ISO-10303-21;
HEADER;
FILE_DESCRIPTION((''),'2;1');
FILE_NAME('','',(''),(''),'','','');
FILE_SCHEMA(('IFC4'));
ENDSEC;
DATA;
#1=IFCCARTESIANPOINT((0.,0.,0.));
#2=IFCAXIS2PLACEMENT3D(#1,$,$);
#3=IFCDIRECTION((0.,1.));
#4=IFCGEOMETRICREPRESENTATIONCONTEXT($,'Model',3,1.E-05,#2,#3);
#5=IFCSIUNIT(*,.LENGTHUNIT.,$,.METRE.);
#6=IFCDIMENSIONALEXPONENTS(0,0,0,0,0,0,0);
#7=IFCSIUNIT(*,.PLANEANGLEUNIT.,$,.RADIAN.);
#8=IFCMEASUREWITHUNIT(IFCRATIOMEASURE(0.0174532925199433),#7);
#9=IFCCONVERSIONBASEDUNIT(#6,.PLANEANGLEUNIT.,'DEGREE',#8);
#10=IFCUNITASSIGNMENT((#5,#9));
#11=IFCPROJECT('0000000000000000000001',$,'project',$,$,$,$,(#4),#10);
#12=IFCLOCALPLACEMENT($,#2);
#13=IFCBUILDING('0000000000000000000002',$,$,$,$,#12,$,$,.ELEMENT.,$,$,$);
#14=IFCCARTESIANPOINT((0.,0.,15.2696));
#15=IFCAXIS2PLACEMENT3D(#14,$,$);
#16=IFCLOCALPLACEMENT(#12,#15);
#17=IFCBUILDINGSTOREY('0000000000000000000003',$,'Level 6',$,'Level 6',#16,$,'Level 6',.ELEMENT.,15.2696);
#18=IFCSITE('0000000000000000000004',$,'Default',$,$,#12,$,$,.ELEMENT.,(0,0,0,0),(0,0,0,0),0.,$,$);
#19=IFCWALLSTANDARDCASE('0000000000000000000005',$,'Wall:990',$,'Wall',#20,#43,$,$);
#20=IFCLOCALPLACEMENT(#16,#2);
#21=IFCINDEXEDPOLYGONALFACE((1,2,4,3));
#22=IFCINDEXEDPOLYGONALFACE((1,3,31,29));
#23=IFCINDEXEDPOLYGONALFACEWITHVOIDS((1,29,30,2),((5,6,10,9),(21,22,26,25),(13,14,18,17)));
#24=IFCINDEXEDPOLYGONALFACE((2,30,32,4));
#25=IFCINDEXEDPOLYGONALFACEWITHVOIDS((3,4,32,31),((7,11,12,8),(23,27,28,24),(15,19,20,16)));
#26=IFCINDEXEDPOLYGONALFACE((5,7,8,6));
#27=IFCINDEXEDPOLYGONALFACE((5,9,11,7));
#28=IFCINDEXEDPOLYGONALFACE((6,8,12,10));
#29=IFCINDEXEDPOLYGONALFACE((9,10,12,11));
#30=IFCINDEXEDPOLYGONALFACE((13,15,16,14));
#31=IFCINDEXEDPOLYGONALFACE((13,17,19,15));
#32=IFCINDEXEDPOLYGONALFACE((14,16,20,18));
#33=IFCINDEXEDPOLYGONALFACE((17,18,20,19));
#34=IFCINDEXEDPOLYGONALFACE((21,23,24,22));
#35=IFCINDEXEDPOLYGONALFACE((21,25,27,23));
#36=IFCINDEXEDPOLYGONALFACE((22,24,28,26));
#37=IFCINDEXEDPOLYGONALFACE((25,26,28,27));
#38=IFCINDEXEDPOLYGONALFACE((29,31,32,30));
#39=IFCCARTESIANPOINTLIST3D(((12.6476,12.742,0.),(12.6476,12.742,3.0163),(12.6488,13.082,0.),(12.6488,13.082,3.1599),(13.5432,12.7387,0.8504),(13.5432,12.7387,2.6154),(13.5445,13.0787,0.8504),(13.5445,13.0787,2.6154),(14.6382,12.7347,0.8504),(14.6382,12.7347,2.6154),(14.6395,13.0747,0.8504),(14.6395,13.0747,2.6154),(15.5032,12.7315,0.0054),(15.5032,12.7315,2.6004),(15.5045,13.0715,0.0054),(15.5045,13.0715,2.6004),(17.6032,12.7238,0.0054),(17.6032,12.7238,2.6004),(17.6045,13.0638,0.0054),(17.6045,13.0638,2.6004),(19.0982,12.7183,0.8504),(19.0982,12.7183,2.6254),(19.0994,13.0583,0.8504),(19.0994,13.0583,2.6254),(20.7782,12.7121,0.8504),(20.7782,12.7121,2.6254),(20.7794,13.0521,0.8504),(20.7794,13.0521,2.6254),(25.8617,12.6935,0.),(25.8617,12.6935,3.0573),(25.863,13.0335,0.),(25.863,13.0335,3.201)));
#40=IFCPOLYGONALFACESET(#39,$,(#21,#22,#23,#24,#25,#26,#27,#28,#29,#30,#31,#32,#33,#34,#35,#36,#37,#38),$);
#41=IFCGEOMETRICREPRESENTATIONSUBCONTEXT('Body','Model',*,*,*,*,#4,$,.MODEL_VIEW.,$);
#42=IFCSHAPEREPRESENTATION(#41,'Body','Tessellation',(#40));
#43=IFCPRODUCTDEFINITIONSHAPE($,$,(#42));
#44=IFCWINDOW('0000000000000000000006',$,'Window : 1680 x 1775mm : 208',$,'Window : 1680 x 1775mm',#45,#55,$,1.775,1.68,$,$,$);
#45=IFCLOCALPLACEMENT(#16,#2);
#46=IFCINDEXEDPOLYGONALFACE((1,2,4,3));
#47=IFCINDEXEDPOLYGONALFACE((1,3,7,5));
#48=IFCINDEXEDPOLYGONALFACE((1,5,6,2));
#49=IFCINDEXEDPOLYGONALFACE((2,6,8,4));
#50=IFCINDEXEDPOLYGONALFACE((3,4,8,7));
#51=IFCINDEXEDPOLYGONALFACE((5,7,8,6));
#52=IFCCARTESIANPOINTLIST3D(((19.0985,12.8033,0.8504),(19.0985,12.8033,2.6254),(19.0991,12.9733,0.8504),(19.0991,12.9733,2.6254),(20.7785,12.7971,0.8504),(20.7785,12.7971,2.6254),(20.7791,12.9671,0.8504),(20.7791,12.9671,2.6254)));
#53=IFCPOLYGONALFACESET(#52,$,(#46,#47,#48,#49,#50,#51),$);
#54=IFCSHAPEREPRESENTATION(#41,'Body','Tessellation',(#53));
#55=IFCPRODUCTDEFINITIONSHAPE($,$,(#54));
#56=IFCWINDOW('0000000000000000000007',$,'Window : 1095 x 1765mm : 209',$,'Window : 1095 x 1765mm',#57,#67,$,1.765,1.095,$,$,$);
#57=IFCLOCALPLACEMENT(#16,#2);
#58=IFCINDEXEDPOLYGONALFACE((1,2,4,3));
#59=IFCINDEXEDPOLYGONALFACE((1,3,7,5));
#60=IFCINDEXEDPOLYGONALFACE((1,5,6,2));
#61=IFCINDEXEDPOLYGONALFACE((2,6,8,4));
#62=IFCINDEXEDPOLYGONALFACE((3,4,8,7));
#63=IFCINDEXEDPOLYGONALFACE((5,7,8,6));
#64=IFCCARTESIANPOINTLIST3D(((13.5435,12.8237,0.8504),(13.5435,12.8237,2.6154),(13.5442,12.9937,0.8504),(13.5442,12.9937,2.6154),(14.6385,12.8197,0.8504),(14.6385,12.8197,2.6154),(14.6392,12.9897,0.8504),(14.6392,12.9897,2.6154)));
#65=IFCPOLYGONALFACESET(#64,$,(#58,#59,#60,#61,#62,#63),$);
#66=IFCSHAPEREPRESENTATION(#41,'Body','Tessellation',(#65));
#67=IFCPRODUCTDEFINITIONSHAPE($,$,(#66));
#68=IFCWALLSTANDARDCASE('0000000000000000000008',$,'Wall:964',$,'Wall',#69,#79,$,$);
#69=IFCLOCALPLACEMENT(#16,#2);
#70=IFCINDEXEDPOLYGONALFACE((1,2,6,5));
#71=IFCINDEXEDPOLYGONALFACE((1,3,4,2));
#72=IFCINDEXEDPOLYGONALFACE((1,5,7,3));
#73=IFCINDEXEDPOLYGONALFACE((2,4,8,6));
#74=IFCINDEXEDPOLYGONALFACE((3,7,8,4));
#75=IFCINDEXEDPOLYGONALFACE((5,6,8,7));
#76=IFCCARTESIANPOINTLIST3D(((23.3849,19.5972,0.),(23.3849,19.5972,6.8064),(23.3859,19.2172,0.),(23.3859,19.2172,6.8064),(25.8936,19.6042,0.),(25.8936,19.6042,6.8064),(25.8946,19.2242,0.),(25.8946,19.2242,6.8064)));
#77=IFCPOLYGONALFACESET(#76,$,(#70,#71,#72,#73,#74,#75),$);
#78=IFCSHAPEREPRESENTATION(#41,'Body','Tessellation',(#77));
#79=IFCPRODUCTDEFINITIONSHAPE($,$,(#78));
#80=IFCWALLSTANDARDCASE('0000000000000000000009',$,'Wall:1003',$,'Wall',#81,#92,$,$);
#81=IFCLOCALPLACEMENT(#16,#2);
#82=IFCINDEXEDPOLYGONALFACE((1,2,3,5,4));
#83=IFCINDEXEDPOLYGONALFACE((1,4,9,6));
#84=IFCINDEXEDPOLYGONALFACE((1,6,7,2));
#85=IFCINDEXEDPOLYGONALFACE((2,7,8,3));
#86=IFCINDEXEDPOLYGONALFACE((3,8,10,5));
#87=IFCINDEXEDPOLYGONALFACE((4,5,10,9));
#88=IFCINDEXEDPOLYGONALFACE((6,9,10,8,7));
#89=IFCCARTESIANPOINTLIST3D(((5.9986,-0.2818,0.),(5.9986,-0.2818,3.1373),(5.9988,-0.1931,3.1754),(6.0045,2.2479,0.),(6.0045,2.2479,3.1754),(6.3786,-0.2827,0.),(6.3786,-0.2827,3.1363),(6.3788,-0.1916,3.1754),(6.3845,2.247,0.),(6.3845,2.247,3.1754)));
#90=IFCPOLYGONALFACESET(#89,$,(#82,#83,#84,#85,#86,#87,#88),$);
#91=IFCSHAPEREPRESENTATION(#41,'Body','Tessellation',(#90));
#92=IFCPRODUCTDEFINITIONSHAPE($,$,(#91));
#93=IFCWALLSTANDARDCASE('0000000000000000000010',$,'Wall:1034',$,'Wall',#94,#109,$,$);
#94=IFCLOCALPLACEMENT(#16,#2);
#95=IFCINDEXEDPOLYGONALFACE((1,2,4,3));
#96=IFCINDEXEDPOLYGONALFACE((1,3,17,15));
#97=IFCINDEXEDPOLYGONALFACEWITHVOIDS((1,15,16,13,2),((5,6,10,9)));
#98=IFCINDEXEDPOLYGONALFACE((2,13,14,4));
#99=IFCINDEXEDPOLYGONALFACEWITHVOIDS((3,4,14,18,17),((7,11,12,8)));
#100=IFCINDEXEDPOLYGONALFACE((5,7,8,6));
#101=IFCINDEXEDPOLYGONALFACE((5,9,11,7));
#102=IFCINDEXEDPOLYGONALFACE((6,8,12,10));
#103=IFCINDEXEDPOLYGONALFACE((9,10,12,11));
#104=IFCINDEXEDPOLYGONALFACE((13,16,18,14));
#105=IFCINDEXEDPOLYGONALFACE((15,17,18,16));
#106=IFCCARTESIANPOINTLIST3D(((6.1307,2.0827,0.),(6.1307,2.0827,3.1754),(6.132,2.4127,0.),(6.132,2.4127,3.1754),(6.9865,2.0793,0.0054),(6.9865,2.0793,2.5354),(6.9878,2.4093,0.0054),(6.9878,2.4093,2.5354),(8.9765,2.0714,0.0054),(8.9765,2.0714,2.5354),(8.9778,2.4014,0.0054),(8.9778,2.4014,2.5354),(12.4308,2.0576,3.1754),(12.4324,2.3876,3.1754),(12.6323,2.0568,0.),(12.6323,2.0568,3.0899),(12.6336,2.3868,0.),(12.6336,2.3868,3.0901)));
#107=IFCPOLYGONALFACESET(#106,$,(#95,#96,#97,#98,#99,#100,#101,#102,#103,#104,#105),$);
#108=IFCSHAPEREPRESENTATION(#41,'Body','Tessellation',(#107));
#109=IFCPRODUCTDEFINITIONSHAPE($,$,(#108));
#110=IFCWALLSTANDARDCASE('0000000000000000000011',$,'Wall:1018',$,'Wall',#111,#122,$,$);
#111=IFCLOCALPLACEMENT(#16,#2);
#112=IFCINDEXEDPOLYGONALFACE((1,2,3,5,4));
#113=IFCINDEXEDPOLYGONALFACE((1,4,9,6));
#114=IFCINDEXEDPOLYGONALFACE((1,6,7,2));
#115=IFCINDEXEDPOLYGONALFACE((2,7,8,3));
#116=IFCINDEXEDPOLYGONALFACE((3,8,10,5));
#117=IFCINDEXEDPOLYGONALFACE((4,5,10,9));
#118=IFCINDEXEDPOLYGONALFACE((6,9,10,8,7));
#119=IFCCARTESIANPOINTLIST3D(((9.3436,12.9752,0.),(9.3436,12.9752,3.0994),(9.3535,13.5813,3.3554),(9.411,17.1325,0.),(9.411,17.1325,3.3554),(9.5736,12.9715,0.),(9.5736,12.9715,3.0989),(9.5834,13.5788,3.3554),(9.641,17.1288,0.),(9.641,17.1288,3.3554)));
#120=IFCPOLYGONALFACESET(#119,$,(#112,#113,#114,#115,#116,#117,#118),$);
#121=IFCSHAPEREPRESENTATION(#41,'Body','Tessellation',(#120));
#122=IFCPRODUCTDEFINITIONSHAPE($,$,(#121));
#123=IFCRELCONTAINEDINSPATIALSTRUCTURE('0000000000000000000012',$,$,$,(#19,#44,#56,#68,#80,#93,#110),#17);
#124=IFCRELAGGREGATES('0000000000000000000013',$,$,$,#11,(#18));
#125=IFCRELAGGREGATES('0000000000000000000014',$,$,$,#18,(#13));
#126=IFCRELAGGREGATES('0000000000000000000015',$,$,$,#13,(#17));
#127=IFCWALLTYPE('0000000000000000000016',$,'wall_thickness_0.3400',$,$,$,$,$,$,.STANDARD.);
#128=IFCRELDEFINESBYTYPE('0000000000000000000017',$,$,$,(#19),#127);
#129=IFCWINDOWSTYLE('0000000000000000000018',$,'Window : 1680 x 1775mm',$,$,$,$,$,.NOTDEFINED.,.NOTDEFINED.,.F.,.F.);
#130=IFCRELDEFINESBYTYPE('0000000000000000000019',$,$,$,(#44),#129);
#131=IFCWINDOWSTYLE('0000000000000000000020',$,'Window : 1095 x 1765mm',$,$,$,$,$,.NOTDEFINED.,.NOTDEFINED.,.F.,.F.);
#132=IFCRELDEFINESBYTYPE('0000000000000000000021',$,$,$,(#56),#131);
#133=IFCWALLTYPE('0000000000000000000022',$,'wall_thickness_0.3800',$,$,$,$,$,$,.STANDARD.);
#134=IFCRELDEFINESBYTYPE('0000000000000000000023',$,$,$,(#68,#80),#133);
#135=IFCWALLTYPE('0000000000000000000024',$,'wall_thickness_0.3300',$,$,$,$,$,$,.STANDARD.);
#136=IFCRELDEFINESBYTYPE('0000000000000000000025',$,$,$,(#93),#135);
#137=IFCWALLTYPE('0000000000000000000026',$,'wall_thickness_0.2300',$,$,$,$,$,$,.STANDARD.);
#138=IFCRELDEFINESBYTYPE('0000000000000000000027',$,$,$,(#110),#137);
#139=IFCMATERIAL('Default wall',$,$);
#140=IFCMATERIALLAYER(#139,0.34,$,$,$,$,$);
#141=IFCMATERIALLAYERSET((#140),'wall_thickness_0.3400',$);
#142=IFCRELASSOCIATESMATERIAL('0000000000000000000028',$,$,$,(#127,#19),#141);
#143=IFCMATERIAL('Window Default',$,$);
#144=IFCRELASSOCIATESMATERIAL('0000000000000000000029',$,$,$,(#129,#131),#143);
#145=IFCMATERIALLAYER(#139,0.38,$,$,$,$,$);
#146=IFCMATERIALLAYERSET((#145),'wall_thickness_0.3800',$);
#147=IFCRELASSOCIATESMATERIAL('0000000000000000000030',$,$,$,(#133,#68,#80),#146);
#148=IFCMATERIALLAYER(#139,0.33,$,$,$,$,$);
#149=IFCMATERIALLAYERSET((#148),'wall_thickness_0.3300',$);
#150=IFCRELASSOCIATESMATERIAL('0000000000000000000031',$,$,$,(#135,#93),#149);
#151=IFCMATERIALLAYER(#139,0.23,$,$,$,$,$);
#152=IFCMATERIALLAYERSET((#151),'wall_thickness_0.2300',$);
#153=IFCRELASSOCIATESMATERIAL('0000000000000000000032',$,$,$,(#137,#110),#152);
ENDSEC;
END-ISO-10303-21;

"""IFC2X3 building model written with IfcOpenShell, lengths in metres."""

from ifc_helpers import new_model, entity, si_unit, converted_unit, direction, frame, frame_2d, origin, origin_2d_with_axis, place, context, subcontext, project, spatial, polyline, rectangle, outline, extrude, clip, halfspace, source, transform, mapped, material, layer, layer_set, layer_usage, type_object, type_shapes, element, fill, save


model = new_model("IFC2X3")

# Units and contexts
model_context = context("Model", 3, precision=1e-05, world=origin(), true_north=direction((0.0, 1.0)))
body_context = subcontext(model_context, "Body", "Model", "MODEL_VIEW")
ifc_project = project(units=[si_unit("LENGTHUNIT", "METRE"), converted_unit("PLANEANGLEUNIT", "DEGREE", entity("IfcRatioMeasure", 0.0174532925199433), si_unit("PLANEANGLEUNIT", "RADIAN"), dimensions=[0, 0, 0, 0, 0, 0, 0])], contexts=[model_context])

# Site, building, storey
placement = place(None, origin())
site = spatial("IfcSite", under=ifc_project, at=placement, Name="Default", CompositionType="ELEMENT", RefLatitude=(0, 0, 0, 0), RefLongitude=(0, 0, 0, 0), RefElevation=0.0)
building = spatial("IfcBuilding", under=site, at=placement, CompositionType="ELEMENT")
storey_placement = place(placement, frame((0.0, 0.0, 15.2696)))
storey = spatial("IfcBuildingStorey", under=building, at=storey_placement, Name="Level 6", ObjectType="Level 6", LongName="Level 6", CompositionType="ELEMENT", Elevation=15.2696)

# Shared definitions
ifc_material_1 = material(Name="Default wall")

# Shared definitions
ifc_material_2 = material(Name="Window Default")

# Wall, openings, windows
ifc_layer_1 = layer(ifc_material_1, 0.34)
ifc_layer_set_1 = layer_set([ifc_layer_1], Name="wall_thickness_0.3400")
ifc_layer_usage_1 = layer_usage(ifc_layer_set_1, "AXIS2", "POSITIVE", -0.17)
wall_type_1 = type_object("IfcWallType", Name="wall_thickness_0.3400", PredefinedType="STANDARD", material=ifc_layer_set_1)
wall_1_placement = place(storey_placement, frame((12.6482, 12.912, 0.0), z_axis=(0.0, 0.0, 1.0), x_axis=(0.999993, -0.003668, 0.0)))
wall_1 = element("IfcWallStandardCase", 1, at=wall_1_placement, inside=storey, type_object=wall_type_1, material=ifc_layer_usage_1, Name="Wall:990", ObjectType="Wall", context=body_context, shape_type="Clipping", body=[
    clip(extrude(outline(polyline([(13.2143, -0.17), (13.2143, 0.17), (0.0, 0.17), (0.0, -0.17), (13.2143, -0.17)])), origin(), (0.0, 0.0, 1.0), 5.0854), halfspace(frame((-24.7058, 6.5913, 5.7956), z_axis=(-0.002864, -0.38913, 0.921178), x_axis=(0.999981, -0.00615, 0.000511)), False)),
])
opening_1_placement = place(wall_1_placement, frame((2.8557, -0.17, 0.0054)))
element("IfcOpeningElement", 2, at=opening_1_placement, cuts=wall_1, ObjectType="Opening", context=body_context, shape_type="SweptSolid", body=[
    extrude(rectangle(XDim=2.1, YDim=2.595, at=frame_2d((1.2975, 1.05), x_axis=(0.0, 1.0))), frame((0.0, 0.0, 0.0), z_axis=(0.0, 1.0, 0.0), x_axis=(0.0, 0.0, 1.0)), (0.0, 0.0, 1.0), 0.34),
])
opening_2_placement = place(wall_1_placement, frame((6.4507, -0.17, 0.8504)))
opening_2 = element("IfcOpeningElement", 3, at=opening_2_placement, cuts=wall_1, ObjectType="Opening", context=body_context, shape_type="SweptSolid", body=[
    extrude(rectangle(XDim=1.68, YDim=1.775, at=frame_2d((0.8875, 0.84), x_axis=(0.0, 1.0))), frame((0.0, 0.0, 0.0), z_axis=(0.0, 1.0, 0.0), x_axis=(0.0, 0.0, 1.0)), (0.0, 0.0, 1.0), 0.34),
])
opening_3_placement = place(wall_1_placement, frame((0.8957, -0.17, 0.8504)))
opening_3 = element("IfcOpeningElement", 4, at=opening_3_placement, cuts=wall_1, ObjectType="Opening", context=body_context, shape_type="SweptSolid", body=[
    extrude(rectangle(XDim=1.095, YDim=1.765, at=frame_2d((0.8825, 0.5475), x_axis=(0.0, 1.0))), frame((0.0, 0.0, 0.0), z_axis=(0.0, 1.0, 0.0), x_axis=(0.0, 0.0, 1.0)), (0.0, 0.0, 1.0), 0.34),
])
window_style_1 = type_object("IfcWindowStyle", Name="Window : 1680 x 1775mm", ConstructionType="NOTDEFINED", OperationType="NOTDEFINED", ParameterTakesPrecedence=False, Sizeable=False, material=ifc_material_2)
shared_shape_1 = source(origin(), body_context, "Body", "SweptSolid", [
    extrude(rectangle(XDim=0.17, YDim=1.68, at=origin_2d_with_axis()), frame((0.84, 0.17, 0.0), z_axis=(0.0, 0.0, 1.0), x_axis=(0.0, 1.0, 0.0)), (0.0, 0.0, 1.0), 1.775),
])
type_shapes(window_style_1, [shared_shape_1])
window_1_placement = place(opening_2_placement, origin())
window_1 = element("IfcWindow", 5, at=window_1_placement, inside=storey, type_object=window_style_1, Name="Window : 1680 x 1775mm : 208", ObjectType="Window : 1680 x 1775mm", OverallHeight=1.775, OverallWidth=1.68, context=body_context, shape_type="MappedRepresentation", body=[
    mapped(shared_shape_1, transform((0.0, 0.0, 0.0), scale=1.0)),
])
fill(opening_2, window_1)
window_style_2 = type_object("IfcWindowStyle", Name="Window : 1095 x 1765mm", ConstructionType="NOTDEFINED", OperationType="NOTDEFINED", ParameterTakesPrecedence=False, Sizeable=False, material=ifc_material_2)
shared_shape_2 = source(origin(), body_context, "Body", "SweptSolid", [
    extrude(rectangle(XDim=0.17, YDim=1.095, at=origin_2d_with_axis()), frame((0.5475, 0.17, 0.0), z_axis=(0.0, 0.0, 1.0), x_axis=(0.0, 1.0, 0.0)), (0.0, 0.0, 1.0), 1.765),
])
type_shapes(window_style_2, [shared_shape_2])
window_2_placement = place(opening_3_placement, origin())
window_2 = element("IfcWindow", 6, at=window_2_placement, inside=storey, type_object=window_style_2, Name="Window : 1095 x 1765mm : 209", ObjectType="Window : 1095 x 1765mm", OverallHeight=1.765, OverallWidth=1.095, context=body_context, shape_type="MappedRepresentation", body=[
    mapped(shared_shape_2, transform((0.0, 0.0, 0.0), scale=1.0)),
])
fill(opening_3, window_2)

# Walls
ifc_layer_2 = layer(ifc_material_1, 0.38)
ifc_layer_set_2 = layer_set([ifc_layer_2], Name="wall_thickness_0.3800")
ifc_layer_usage_2 = layer_usage(ifc_layer_set_2, "AXIS2", "POSITIVE", -0.19)
wall_type_2 = type_object("IfcWallType", Name="wall_thickness_0.3800", PredefinedType="STANDARD", material=ifc_layer_set_2)
wall_2_placement = place(storey_placement, frame((23.3854, 19.4072, 0.0), z_axis=(0.0, 0.0, 1.0), x_axis=(0.999996, 0.002756, 0.0)))
element("IfcWallStandardCase", 7, at=wall_2_placement, inside=storey, type_object=wall_type_2, material=ifc_layer_usage_2, Name="Wall:964", ObjectType="Wall", context=body_context, shape_type="SweptSolid", body=[
    extrude(outline(polyline([(2.5087, -0.19), (2.5087, 0.19), (0.0, 0.19), (0.0, -0.19), (2.5087, -0.19)])), origin(), (0.0, 0.0, 1.0), 6.8064),
])
wall_3_placement = place(storey_placement, frame((6.1945, 2.2474, 0.0), z_axis=(0.0, 0.0, 1.0), x_axis=(-0.002327, -0.999997, 0.0)))
element("IfcWallStandardCase", 8, at=wall_3_placement, inside=storey, type_object=wall_type_2, material=ifc_layer_usage_2, Name="Wall:1003", ObjectType="Wall", context=body_context, shape_type="Clipping", body=[
    clip(extrude(outline(polyline([(2.5297, -0.19), (2.5297, 0.19), (0.0, 0.19), (0.0, -0.19), (2.5297, -0.19)])), origin(), (0.0, 0.0, 1.0), 3.1754), halfspace(frame((3.6108, -7.5414, 2.6926), z_axis=(0.394843, 0.002486, 0.918745), x_axis=(-0.006295, 0.99998, 0.0)), False)),
])

# Wall, opening
ifc_layer_3 = layer(ifc_material_1, 0.33)
ifc_layer_set_3 = layer_set([ifc_layer_3], Name="wall_thickness_0.3300")
ifc_layer_usage_3 = layer_usage(ifc_layer_set_3, "AXIS2", "POSITIVE", -0.165)
wall_type_3 = type_object("IfcWallType", Name="wall_thickness_0.3300", PredefinedType="STANDARD", material=ifc_layer_set_3)
wall_4_placement = place(storey_placement, frame((6.1314, 2.2477, 0.0), z_axis=(0.0, 0.0, 1.0), x_axis=(0.999992, -0.003974, 0.0)))
wall_4 = element("IfcWallStandardCase", 9, at=wall_4_placement, inside=storey, type_object=wall_type_3, material=ifc_layer_usage_3, Name="Wall:1034", ObjectType="Wall", context=body_context, shape_type="Clipping", body=[
    clip(clip(extrude(outline(polyline([(6.5017, -0.165), (6.5017, 0.165), (0.0, 0.165), (0.0, -0.165), (6.5017, -0.165)])), origin(), (0.0, 0.0, 1.0), 3.1754), halfspace(frame((7.6527, 75.0169, 2.6304), z_axis=(0.390505, -0.000352, 0.920601), x_axis=(-0.920601, 0.000333, 0.390505)), False)), halfspace(frame((-7.4724, -3.6232, 2.6926), z_axis=(0.003136, -0.394838, 0.918745), x_axis=(0.999968, 0.007942, 0.0)), False)),
])
opening_4_placement = place(wall_4_placement, frame((0.8558, -0.165, 0.0054)))
element("IfcOpeningElement", 10, at=opening_4_placement, cuts=wall_4, ObjectType="Opening", context=body_context, shape_type="SweptSolid", body=[
    extrude(rectangle(XDim=1.99, YDim=2.53, at=frame_2d((1.265, 0.995), x_axis=(0.0, 1.0))), frame((0.0, 0.0, 0.0), z_axis=(0.0, 1.0, 0.0), x_axis=(0.0, 0.0, 1.0)), (0.0, 0.0, 1.0), 0.33),
])

# Wall
ifc_layer_4 = layer(ifc_material_1, 0.23)
ifc_layer_set_4 = layer_set([ifc_layer_4], Name="wall_thickness_0.2300")
ifc_layer_usage_4 = layer_usage(ifc_layer_set_4, "AXIS2", "POSITIVE", -0.115)
wall_type_4 = type_object("IfcWallType", Name="wall_thickness_0.2300", PredefinedType="STANDARD", material=ifc_layer_set_4)
wall_5_placement = place(storey_placement, frame((9.526, 17.1307, 0.0), z_axis=(0.0, 0.0, 1.0), x_axis=(-0.016203, -0.999869, 0.0)))
element("IfcWallStandardCase", 11, at=wall_5_placement, inside=storey, type_object=wall_type_4, material=ifc_layer_usage_4, Name="Wall:1018", ObjectType="Wall", context=body_context, shape_type="Clipping", body=[
    clip(clip(extrude(outline(polyline([(4.1579, -0.115), (4.1579, 0.115), (0.0, 0.115), (0.0, -0.115), (4.1579, -0.115)])), origin(), (0.0, 0.0, 1.0), 3.3554), halfspace(frame((-60.1688, 3.5817, 2.6304), z_axis=(-0.004424, 0.39048, 0.920601), x_axis=(0.010925, -0.920536, 0.390505)), False)), halfspace(frame((-2.1135, -21.5963, 5.7956), z_axis=(0.389135, 0.002014, 0.921178), x_axis=(-0.006385, 0.999979, 0.000511)), False)),
])

save(model, "model.ifc")
